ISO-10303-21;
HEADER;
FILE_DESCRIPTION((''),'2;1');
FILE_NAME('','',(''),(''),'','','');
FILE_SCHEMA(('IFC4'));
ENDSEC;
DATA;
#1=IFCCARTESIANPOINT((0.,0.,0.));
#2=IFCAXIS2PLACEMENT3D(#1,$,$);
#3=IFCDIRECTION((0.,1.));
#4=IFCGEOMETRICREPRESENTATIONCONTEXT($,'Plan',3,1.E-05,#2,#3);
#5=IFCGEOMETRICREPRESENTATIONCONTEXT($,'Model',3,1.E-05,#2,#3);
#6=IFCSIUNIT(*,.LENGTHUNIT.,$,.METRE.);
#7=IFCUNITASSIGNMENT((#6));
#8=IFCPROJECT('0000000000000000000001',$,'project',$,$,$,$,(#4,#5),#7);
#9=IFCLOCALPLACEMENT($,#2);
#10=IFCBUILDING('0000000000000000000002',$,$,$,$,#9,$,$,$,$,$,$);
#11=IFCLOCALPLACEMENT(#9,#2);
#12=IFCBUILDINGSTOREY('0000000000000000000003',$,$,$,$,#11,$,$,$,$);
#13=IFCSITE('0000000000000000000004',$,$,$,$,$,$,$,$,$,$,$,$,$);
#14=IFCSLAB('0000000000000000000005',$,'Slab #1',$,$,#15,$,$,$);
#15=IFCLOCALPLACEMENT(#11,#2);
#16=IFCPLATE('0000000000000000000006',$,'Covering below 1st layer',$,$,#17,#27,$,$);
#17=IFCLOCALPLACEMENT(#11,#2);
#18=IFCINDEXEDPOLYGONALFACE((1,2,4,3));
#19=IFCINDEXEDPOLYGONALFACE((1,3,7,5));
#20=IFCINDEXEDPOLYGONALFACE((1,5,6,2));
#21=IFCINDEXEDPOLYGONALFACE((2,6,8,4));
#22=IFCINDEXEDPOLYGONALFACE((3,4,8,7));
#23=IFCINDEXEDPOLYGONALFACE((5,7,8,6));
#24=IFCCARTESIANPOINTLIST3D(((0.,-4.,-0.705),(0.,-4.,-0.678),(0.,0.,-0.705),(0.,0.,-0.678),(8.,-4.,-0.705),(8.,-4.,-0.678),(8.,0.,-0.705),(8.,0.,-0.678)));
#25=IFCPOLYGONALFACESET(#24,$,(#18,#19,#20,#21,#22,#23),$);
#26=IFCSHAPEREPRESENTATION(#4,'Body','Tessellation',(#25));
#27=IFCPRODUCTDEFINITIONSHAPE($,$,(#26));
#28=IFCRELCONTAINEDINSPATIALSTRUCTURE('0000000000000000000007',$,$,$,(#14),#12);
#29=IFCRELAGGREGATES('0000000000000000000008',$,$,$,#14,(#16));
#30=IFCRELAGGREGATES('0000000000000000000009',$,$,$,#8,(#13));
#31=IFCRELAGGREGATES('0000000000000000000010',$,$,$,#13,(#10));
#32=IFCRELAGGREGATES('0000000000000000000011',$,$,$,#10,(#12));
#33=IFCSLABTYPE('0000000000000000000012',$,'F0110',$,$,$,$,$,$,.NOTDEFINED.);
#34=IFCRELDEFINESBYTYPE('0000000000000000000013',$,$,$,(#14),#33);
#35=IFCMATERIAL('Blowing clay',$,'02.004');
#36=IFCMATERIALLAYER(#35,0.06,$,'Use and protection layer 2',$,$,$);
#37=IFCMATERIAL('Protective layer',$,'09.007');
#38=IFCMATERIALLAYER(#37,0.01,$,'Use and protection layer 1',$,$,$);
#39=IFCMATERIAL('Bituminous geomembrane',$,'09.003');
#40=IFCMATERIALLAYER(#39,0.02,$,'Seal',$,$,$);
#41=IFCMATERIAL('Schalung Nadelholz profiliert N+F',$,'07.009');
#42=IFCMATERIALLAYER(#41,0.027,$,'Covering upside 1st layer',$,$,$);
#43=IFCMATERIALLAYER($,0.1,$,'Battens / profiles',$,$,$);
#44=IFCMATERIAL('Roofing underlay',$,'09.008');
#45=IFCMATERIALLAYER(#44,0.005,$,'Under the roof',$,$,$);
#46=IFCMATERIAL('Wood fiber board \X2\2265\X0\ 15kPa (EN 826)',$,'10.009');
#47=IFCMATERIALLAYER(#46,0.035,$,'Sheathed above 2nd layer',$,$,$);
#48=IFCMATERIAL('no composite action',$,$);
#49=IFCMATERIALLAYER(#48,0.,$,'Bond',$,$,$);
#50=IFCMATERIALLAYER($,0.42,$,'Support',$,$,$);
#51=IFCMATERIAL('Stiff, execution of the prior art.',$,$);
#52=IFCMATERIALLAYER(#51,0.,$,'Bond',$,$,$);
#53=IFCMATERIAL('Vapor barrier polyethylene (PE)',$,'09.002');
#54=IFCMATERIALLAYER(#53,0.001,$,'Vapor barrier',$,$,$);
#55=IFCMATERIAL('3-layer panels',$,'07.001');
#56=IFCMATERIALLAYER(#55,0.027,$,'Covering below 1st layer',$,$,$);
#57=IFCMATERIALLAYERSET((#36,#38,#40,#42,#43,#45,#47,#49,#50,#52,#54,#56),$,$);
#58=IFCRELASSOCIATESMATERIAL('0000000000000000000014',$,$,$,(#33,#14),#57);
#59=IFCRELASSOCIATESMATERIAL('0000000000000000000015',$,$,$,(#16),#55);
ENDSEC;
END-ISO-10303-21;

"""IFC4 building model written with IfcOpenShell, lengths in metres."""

from ifc_helpers import new_model, si_unit, direction, frame, frame_2d, origin, place, context, project, spatial, rectangle, extrude, material, layer, layer_set, type_object, element, aggregate, save


model = new_model("IFC4")

# Units and contexts
plan_context = context("Plan", 3, precision=1e-05, world=origin(), true_north=direction((0.0, 1.0)))
model_context = context("Model", 3, precision=1e-05, world=origin(), true_north=direction((0.0, 1.0)))
ifc_project = project(units=[si_unit("LENGTHUNIT", "METRE")], contexts=[plan_context, model_context])

# Site, building, storey
site = spatial("IfcSite", under=ifc_project)
building_placement = place(None, origin())
building = spatial("IfcBuilding", under=site, at=building_placement)
storey_placement = place(building_placement, origin())
storey = spatial("IfcBuildingStorey", under=building, at=storey_placement)

# Slab, plate
ifc_material_1 = material(Name="Blowing clay", Category="02.004")
ifc_layer_1 = layer(ifc_material_1, 0.06, Name="Use and protection layer 2")
ifc_material_2 = material(Name="Protective layer", Category="09.007")
ifc_layer_2 = layer(ifc_material_2, 0.01, Name="Use and protection layer 1")
ifc_material_3 = material(Name="Bituminous geomembrane", Category="09.003")
ifc_layer_3 = layer(ifc_material_3, 0.02, Name="Seal")
ifc_material_4 = material(Name="Schalung Nadelholz profiliert N+F", Category="07.009")
ifc_layer_4 = layer(ifc_material_4, 0.027, Name="Covering upside 1st layer")
ifc_layer_5 = layer(None, 0.1, Name="Battens / profiles")
ifc_material_5 = material(Name="Roofing underlay", Category="09.008")
ifc_layer_6 = layer(ifc_material_5, 0.005, Name="Under the roof")
ifc_material_6 = material(Name="Wood fiber board ≥ 15kPa (EN 826)", Category="10.009")
ifc_layer_7 = layer(ifc_material_6, 0.035, Name="Sheathed above 2nd layer")
ifc_material_7 = material(Name="no composite action")
ifc_layer_8 = layer(ifc_material_7, 0.0, Name="Bond")
ifc_layer_9 = layer(None, 0.42, Name="Support")
ifc_material_8 = material(Name="Stiff, execution of the prior art.")
ifc_layer_10 = layer(ifc_material_8, 0.0, Name="Bond")
ifc_material_9 = material(Name="Vapor barrier polyethylene (PE)", Category="09.002")
ifc_layer_11 = layer(ifc_material_9, 0.001, Name="Vapor barrier")
ifc_material_10 = material(Name="3-layer panels", Category="07.001")
ifc_layer_12 = layer(ifc_material_10, 0.027, Name="Covering below 1st layer")
ifc_layer_set = layer_set([ifc_layer_1, ifc_layer_2, ifc_layer_3, ifc_layer_4, ifc_layer_5, ifc_layer_6, ifc_layer_7, ifc_layer_8, ifc_layer_9, ifc_layer_10, ifc_layer_11, ifc_layer_12])
slab_type = type_object("IfcSlabType", Name="F0110", PredefinedType="NOTDEFINED", material=ifc_layer_set)
slab_placement = place(None, frame((0.0, 0.0, 0.0), z_axis=(0.0, 0.0, -1.0), x_axis=(1.0, 0.0, 0.0)))
slab = element("IfcSlab", 1, at=slab_placement, inside=storey, type_object=slab_type, material=ifc_layer_set, Name="Slab #1")
plate_1_placement = place(slab_placement, origin())
plate_1 = element("IfcPlate", 2, at=plate_1_placement, material=ifc_material_10, Name="Covering below 1st layer", context=plan_context, shape_type="SweptSolid", body=[
    extrude(rectangle(XDim=8.0, YDim=4.0, at=frame_2d((4.0, 2.0), x_axis=(1.0, 0.0))), frame((0.0, 0.0, 0.678), z_axis=(0.0, 0.0, 1.0), x_axis=(1.0, 0.0, 0.0)), (0.0, 0.0, 1.0), 0.027),
])
aggregate(slab, [plate_1])

save(model, "model.ifc")
